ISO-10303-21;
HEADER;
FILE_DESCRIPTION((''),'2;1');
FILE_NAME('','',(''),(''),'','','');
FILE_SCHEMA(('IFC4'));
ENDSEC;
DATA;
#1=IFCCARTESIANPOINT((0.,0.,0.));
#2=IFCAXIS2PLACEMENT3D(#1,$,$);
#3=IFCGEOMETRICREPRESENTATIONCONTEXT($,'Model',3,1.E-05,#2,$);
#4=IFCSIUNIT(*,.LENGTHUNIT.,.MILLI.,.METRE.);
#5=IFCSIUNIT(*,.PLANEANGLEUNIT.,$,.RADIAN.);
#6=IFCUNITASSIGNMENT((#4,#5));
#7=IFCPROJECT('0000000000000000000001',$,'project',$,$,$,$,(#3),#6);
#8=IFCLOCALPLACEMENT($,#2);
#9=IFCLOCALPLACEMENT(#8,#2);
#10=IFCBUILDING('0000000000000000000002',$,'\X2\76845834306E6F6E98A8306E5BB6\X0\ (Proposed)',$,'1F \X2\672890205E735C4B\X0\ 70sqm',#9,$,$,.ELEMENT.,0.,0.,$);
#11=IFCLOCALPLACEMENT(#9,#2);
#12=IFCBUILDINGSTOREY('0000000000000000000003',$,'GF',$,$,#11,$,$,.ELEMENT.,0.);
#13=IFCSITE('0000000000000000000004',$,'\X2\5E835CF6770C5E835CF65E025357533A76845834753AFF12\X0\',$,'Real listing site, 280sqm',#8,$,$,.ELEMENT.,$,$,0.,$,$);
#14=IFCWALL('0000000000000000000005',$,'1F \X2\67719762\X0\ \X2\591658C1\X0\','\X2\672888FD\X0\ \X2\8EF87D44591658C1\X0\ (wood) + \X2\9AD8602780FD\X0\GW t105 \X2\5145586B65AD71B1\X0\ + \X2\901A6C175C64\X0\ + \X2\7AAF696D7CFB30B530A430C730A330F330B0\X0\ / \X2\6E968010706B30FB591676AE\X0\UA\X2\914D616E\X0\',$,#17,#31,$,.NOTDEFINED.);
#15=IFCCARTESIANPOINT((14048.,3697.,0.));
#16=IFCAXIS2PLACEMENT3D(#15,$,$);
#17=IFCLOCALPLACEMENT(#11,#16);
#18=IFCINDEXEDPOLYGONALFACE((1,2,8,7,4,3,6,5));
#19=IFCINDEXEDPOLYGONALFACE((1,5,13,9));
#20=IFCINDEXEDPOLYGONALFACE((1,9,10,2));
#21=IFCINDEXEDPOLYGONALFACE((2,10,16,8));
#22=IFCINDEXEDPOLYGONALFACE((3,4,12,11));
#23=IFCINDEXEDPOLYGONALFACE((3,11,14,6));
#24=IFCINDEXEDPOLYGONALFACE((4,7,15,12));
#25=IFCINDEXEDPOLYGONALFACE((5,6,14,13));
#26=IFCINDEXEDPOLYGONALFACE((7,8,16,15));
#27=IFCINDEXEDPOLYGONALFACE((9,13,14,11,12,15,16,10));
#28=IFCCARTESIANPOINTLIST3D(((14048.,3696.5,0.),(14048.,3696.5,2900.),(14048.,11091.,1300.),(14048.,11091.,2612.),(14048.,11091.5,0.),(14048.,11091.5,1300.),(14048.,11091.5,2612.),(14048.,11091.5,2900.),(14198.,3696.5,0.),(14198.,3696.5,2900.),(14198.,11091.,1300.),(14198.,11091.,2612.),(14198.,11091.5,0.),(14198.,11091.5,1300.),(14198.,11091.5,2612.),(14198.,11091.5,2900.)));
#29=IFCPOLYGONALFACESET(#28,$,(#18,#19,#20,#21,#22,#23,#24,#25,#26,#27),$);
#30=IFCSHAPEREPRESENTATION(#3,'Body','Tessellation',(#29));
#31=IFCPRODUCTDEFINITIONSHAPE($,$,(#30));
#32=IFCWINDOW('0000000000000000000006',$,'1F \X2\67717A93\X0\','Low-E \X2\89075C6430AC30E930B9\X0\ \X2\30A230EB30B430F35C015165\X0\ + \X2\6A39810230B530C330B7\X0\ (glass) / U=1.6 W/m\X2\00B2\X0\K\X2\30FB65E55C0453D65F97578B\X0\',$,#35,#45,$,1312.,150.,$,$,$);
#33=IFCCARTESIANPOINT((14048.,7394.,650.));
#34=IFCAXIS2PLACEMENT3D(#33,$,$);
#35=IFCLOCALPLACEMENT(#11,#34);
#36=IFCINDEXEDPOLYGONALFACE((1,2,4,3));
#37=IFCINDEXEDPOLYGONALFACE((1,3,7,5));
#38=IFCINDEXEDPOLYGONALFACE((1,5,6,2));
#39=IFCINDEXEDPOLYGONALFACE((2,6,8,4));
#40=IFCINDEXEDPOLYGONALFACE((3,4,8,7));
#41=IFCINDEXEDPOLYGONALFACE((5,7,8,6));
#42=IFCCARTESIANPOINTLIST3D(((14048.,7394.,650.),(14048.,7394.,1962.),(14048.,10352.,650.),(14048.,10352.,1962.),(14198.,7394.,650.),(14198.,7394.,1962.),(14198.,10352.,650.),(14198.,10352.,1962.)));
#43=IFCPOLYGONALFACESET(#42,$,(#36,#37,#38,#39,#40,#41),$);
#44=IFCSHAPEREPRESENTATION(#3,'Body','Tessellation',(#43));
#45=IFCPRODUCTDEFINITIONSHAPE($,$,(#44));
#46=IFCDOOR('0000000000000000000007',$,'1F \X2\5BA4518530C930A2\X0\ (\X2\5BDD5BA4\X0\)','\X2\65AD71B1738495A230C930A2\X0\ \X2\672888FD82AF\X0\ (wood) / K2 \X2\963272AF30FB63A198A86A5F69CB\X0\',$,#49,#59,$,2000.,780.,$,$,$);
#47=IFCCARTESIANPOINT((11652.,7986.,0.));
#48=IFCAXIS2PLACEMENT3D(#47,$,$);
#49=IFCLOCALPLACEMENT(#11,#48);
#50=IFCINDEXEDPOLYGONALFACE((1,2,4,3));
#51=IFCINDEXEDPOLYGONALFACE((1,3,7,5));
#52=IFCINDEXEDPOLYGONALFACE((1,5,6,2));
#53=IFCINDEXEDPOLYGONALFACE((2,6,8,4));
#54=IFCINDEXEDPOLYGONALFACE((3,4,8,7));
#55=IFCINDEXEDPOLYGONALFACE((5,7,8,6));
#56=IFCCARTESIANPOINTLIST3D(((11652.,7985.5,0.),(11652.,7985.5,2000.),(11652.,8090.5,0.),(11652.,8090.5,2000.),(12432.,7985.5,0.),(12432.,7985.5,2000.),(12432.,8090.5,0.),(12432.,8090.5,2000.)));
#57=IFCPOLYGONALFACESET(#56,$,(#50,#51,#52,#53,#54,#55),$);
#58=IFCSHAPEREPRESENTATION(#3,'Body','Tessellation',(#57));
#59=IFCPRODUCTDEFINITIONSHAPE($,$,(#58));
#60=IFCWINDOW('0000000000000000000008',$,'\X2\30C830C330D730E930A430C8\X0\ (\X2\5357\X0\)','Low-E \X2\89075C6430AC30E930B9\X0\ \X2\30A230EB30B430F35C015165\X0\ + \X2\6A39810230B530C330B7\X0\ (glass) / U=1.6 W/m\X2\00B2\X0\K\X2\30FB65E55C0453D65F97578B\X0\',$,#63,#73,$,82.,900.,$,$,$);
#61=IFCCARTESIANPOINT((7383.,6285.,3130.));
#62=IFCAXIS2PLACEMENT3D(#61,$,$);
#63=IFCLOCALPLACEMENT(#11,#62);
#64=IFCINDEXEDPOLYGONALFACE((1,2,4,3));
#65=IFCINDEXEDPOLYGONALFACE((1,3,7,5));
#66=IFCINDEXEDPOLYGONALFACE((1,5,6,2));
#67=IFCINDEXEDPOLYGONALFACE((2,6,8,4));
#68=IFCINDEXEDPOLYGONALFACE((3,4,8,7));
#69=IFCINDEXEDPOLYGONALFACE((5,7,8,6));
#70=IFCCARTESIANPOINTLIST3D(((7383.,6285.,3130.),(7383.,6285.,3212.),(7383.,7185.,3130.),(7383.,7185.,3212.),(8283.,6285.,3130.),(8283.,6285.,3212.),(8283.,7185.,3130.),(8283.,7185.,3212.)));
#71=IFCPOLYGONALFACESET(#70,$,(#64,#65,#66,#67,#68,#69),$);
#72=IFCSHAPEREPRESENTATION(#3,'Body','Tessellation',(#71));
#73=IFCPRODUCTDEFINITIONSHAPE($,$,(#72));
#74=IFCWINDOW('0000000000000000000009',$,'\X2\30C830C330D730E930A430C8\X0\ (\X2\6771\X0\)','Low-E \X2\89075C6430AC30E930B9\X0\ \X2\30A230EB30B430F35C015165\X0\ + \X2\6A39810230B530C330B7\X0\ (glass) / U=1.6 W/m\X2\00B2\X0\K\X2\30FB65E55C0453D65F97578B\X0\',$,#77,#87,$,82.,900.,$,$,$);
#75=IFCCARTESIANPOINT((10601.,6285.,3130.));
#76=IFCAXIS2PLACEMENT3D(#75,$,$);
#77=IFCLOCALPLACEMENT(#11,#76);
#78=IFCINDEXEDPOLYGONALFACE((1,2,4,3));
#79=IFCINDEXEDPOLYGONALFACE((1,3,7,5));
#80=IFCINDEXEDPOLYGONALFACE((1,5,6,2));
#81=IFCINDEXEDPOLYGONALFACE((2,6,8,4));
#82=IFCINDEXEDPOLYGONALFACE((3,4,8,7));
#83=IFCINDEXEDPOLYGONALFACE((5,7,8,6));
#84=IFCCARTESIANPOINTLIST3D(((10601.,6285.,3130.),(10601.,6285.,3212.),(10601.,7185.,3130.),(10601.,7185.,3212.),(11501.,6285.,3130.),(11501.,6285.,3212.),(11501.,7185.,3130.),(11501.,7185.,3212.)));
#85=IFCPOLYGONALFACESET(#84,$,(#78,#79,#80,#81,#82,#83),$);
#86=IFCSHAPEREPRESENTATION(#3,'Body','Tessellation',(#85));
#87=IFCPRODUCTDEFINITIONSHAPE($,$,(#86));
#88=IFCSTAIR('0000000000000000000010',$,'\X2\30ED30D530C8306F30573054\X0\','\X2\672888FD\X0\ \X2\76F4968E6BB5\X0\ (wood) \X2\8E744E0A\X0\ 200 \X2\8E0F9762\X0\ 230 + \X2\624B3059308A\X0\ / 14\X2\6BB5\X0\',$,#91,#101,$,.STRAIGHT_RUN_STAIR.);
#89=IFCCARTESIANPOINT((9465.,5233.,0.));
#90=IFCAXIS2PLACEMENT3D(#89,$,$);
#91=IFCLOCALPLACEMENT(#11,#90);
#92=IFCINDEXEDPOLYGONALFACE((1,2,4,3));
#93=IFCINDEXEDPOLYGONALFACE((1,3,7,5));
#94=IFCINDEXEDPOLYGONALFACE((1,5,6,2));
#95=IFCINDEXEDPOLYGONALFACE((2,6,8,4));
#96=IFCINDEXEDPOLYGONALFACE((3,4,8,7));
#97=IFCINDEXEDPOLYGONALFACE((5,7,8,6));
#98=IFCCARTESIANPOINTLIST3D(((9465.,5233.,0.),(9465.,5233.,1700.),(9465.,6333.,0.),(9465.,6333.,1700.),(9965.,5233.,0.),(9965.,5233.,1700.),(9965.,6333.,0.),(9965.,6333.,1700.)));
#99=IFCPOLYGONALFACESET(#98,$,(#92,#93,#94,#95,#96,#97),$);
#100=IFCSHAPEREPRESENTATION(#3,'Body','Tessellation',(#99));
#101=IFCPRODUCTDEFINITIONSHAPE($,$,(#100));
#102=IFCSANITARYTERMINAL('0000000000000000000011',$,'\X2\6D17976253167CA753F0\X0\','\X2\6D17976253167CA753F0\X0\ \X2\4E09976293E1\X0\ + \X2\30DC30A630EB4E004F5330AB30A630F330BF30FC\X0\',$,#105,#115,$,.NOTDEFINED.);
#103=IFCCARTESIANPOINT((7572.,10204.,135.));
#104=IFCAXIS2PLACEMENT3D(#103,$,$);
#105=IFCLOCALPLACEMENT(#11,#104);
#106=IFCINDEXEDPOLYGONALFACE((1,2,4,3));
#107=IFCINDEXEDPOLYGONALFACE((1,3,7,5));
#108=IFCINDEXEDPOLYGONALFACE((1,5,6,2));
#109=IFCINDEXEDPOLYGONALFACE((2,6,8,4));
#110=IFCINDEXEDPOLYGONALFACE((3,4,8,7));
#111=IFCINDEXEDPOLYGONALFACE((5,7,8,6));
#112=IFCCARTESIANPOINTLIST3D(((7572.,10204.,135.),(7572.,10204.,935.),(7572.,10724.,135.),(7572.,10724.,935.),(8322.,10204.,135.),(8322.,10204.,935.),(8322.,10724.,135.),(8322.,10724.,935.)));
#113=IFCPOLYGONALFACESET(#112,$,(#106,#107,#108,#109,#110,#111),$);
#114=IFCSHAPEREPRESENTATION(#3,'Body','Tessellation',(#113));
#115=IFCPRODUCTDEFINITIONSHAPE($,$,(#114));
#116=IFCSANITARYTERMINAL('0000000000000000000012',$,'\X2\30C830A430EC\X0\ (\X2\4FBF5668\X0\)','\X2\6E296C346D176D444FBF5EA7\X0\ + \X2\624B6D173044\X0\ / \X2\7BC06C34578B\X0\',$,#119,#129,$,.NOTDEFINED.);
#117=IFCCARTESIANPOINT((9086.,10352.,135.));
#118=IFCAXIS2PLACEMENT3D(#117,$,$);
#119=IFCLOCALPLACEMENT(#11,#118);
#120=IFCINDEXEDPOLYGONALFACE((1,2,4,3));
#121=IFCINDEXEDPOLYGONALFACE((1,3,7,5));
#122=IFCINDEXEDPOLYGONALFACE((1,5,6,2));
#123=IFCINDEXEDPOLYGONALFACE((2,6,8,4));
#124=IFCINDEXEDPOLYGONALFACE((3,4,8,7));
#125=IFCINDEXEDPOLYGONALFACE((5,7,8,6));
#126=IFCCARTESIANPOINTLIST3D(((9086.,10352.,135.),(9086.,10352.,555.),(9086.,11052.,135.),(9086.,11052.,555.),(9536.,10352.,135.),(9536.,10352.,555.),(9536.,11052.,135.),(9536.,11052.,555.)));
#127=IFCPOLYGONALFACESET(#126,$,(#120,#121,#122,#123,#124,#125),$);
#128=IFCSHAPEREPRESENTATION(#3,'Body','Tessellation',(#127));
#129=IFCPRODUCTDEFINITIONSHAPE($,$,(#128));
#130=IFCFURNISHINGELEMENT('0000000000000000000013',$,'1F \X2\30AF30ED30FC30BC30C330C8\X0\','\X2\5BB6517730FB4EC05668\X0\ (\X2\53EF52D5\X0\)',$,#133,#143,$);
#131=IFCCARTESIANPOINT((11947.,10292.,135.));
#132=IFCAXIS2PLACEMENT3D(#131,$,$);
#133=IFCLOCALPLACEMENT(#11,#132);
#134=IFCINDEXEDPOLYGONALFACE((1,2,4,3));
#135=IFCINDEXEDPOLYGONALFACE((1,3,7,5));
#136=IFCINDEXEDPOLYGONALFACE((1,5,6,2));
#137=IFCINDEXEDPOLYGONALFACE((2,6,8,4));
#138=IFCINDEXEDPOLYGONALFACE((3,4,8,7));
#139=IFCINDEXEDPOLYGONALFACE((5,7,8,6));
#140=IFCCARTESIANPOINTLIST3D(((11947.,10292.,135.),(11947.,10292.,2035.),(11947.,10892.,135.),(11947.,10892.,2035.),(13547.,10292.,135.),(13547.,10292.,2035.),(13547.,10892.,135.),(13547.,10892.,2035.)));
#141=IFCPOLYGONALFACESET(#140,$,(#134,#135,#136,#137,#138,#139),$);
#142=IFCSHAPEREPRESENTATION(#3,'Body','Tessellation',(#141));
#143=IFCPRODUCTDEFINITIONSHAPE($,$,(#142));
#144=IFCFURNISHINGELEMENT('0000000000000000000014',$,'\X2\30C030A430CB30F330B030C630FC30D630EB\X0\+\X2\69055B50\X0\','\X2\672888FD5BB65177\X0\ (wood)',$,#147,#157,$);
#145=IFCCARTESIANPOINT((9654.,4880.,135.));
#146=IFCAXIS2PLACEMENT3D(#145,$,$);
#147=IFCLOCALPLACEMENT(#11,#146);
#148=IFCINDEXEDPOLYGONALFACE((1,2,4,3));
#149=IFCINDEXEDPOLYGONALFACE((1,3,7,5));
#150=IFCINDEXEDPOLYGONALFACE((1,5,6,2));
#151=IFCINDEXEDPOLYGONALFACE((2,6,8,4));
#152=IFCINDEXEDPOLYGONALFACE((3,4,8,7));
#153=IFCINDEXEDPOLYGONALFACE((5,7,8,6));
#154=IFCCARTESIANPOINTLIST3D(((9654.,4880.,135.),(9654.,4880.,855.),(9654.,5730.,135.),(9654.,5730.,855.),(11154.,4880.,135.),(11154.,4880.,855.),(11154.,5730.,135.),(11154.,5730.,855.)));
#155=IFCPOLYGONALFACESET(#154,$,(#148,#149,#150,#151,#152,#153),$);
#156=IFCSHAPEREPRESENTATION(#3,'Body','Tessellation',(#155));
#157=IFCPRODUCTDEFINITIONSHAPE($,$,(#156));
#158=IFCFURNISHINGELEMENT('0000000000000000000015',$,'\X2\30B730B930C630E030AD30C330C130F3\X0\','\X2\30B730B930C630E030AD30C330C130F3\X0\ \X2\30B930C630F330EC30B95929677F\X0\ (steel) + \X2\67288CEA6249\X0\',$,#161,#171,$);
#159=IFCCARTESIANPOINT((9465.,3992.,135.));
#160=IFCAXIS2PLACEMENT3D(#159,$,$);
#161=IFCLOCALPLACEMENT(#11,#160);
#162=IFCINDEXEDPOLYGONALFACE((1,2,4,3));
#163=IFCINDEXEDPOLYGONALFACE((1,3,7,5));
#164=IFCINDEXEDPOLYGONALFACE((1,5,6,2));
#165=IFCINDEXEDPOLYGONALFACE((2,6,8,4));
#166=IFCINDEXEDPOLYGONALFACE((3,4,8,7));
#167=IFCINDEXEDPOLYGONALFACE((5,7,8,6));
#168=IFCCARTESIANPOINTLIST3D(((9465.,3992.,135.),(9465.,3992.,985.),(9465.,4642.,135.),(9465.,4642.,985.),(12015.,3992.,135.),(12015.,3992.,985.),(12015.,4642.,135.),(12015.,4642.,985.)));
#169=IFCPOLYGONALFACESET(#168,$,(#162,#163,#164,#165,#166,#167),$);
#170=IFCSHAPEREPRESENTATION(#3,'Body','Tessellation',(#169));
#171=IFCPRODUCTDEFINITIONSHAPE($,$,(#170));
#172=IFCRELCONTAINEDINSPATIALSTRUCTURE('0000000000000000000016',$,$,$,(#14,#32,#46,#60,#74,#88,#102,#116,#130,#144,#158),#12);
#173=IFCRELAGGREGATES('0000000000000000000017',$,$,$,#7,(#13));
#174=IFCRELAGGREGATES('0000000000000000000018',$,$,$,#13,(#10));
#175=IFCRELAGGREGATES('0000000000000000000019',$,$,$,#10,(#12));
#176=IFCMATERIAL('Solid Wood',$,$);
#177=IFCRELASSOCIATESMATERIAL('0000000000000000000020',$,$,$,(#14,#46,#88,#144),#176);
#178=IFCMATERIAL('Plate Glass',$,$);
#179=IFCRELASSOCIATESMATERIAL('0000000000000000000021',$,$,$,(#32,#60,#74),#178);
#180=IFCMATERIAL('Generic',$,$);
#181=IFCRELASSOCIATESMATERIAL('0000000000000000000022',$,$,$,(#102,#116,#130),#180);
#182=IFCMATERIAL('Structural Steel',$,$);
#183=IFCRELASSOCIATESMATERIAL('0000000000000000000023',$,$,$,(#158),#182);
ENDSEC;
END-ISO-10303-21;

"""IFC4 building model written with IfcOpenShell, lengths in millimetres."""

from ifc_helpers import new_model, si_unit, frame, frame_2d, origin, place, context, project, spatial, rectangle, extrude, material, element, fill, save


model = new_model("IFC4")

# Units and contexts
model_context = context("Model", 3, precision=1e-05, world=origin())
ifc_project = project(units=[si_unit("LENGTHUNIT", "METRE", prefix="MILLI"), si_unit("PLANEANGLEUNIT", "RADIAN")], contexts=[model_context])

# Site, building, storey
site_placement = place(None, origin())
site = spatial("IfcSite", under=ifc_project, at=site_placement, Name="広島県広島市南区的場町２", ObjectType="Real listing site, 280sqm", CompositionType="ELEMENT", RefElevation=0.0)
building_placement = place(site_placement, origin())
building = spatial("IfcBuilding", under=site, at=building_placement, Name="的場の潮風の家 (Proposed)", ObjectType="1F 木造平屋 70sqm", CompositionType="ELEMENT", ElevationOfRefHeight=0.0, ElevationOfTerrain=0.0)
storey_placement = place(building_placement, origin())
storey = spatial("IfcBuildingStorey", under=building, at=storey_placement, Name="GF", CompositionType="ELEMENT", Elevation=0.0)

# Wall, opening, window
ifc_material_1 = material(Name="Solid Wood")
wall_1_placement = place(storey_placement, frame((14048.0, 3697.0, 0.0)))
wall_1 = element("IfcWall", 1, at=wall_1_placement, inside=storey, material=ifc_material_1, Name="1F 東面 外壁", Description="木製 軸組外壁 (wood) + 高性能GW t105 充填断熱 + 通気層 + 窯業系サイディング / 準耐火・外皮UA配慮", PredefinedType="NOTDEFINED", context=model_context, shape_type="SweptSolid", body=[
    extrude(rectangle(XDim=150.0, YDim=7395.0, at=frame_2d((75.0, 3697.0))), frame((14048.0, 3697.0, 0.0)), (0.0, 0.0, 1.0), 2900.0),
])
opening_placement = place(storey_placement, frame((14048.0, 7394.0, 650.0)))
opening = element("IfcOpeningElement", 2, at=opening_placement, cuts=wall_1, PredefinedType="NOTDEFINED", context=model_context, shape_type="SweptSolid", body=[
    extrude(rectangle(XDim=150.0, YDim=2958.0, at=frame_2d((75.0, 1479.0))), frame((14048.0, 7394.0, 650.0)), (0.0, 0.0, 1.0), 1312.0),
])
ifc_material_2 = material(Name="Plate Glass")
window_1_placement = place(storey_placement, frame((14048.0, 7394.0, 650.0)))
window_1 = element("IfcWindow", 3, at=window_1_placement, inside=storey, material=ifc_material_2, Name="1F 東窓", Description="Low-E 複層ガラス アルゴン封入 + 樹脂サッシ (glass) / U=1.6 W/m²K・日射取得型", OverallHeight=1312.0, OverallWidth=150.0, context=model_context, shape_type="SweptSolid", body=[
    extrude(rectangle(XDim=150.0, YDim=2958.0, at=frame_2d((75.0, 1479.0))), frame((14048.0, 7394.0, 650.0)), (0.0, 0.0, 1.0), 1312.0),
])
fill(opening, window_1)

# Door
door_placement = place(storey_placement, frame((11652.0, 7986.0, 0.0)))
element("IfcDoor", 4, at=door_placement, inside=storey, material=ifc_material_1, Name="1F 室内ドア (寝室)", Description="断熱玄関ドア 木製芯 (wood) / K2 防犯・採風機構", OverallHeight=2000.0, OverallWidth=780.0, context=model_context, shape_type="SweptSolid", body=[
    extrude(rectangle(XDim=780.0, YDim=105.0, at=frame_2d((390.0, 52.0))), frame((11652.0, 7986.0, 0.0)), (0.0, 0.0, 1.0), 2000.0),
])

# Windows
window_2_placement = place(storey_placement, frame((7383.0, 6285.0, 3130.0)))
element("IfcWindow", 5, at=window_2_placement, inside=storey, material=ifc_material_2, Name="トップライト (南)", Description="Low-E 複層ガラス アルゴン封入 + 樹脂サッシ (glass) / U=1.6 W/m²K・日射取得型", OverallHeight=82.0, OverallWidth=900.0, context=model_context, shape_type="SweptSolid", body=[
    extrude(rectangle(XDim=900.0, YDim=900.0, at=frame_2d((450.0, 450.0))), frame((7383.0, 6285.0, 3130.0)), (0.0, 0.0, 1.0), 82.0),
])
window_3_placement = place(storey_placement, frame((10601.0, 6285.0, 3130.0)))
element("IfcWindow", 6, at=window_3_placement, inside=storey, material=ifc_material_2, Name="トップライト (東)", Description="Low-E 複層ガラス アルゴン封入 + 樹脂サッシ (glass) / U=1.6 W/m²K・日射取得型", OverallHeight=82.0, OverallWidth=900.0, context=model_context, shape_type="SweptSolid", body=[
    extrude(rectangle(XDim=900.0, YDim=900.0, at=frame_2d((450.0, 450.0))), frame((10601.0, 6285.0, 3130.0)), (0.0, 0.0, 1.0), 82.0),
])

# Stair
stair_placement = place(storey_placement, frame((9465.0, 5233.0, 0.0)))
element("IfcStair", 7, at=stair_placement, inside=storey, material=ifc_material_1, Name="ロフトはしご", Description="木製 直階段 (wood) 蹴上 200 踏面 230 + 手すり / 14段", PredefinedType="STRAIGHT_RUN_STAIR", context=model_context, shape_type="SweptSolid", body=[
    extrude(rectangle(XDim=500.0, YDim=1100.0, at=frame_2d((250.0, 550.0))), frame((9465.0, 5233.0, 0.0)), (0.0, 0.0, 1.0), 1700.0),
])

# Sanitary terminals
ifc_material_3 = material(Name="Generic")
sanitary_terminal_1_placement = place(storey_placement, frame((7572.0, 10204.0, 135.0)))
element("IfcSanitaryTerminal", 8, at=sanitary_terminal_1_placement, inside=storey, material=ifc_material_3, Name="洗面化粧台", Description="洗面化粧台 三面鏡 + ボウル一体カウンター", PredefinedType="NOTDEFINED", context=model_context, shape_type="SweptSolid", body=[
    extrude(rectangle(XDim=750.0, YDim=520.0, at=frame_2d((375.0, 260.0))), frame((7572.0, 10204.0, 135.0)), (0.0, 0.0, 1.0), 800.0),
])
sanitary_terminal_2_placement = place(storey_placement, frame((9086.0, 10352.0, 135.0)))
element("IfcSanitaryTerminal", 9, at=sanitary_terminal_2_placement, inside=storey, material=ifc_material_3, Name="トイレ (便器)", Description="温水洗浄便座 + 手洗い / 節水型", PredefinedType="NOTDEFINED", context=model_context, shape_type="SweptSolid", body=[
    extrude(rectangle(XDim=450.0, YDim=700.0, at=frame_2d((225.0, 350.0))), frame((9086.0, 10352.0, 135.0)), (0.0, 0.0, 1.0), 420.0),
])

# Furnishing elements
furnishing_1_placement = place(storey_placement, frame((11947.0, 10292.0, 135.0)))
element("IfcFurnishingElement", 10, at=furnishing_1_placement, inside=storey, material=ifc_material_3, Name="1F クローゼット", Description="家具・什器 (可動)", context=model_context, shape_type="SweptSolid", body=[
    extrude(rectangle(XDim=1600.0, YDim=600.0, at=frame_2d((800.0, 300.0))), frame((11947.0, 10292.0, 135.0)), (0.0, 0.0, 1.0), 1900.0),
])
furnishing_2_placement = place(storey_placement, frame((9654.0, 4880.0, 135.0)))
element("IfcFurnishingElement", 11, at=furnishing_2_placement, inside=storey, material=ifc_material_1, Name="ダイニングテーブル+椅子", Description="木製家具 (wood)", context=model_context, shape_type="SweptSolid", body=[
    extrude(rectangle(XDim=1500.0, YDim=850.0, at=frame_2d((750.0, 425.0))), frame((9654.0, 4880.0, 135.0)), (0.0, 0.0, 1.0), 720.0),
])
ifc_material_4 = material(Name="Structural Steel")
furnishing_3_placement = place(storey_placement, frame((9465.0, 3992.0, 135.0)))
element("IfcFurnishingElement", 12, at=furnishing_3_placement, inside=storey, material=ifc_material_4, Name="システムキッチン", Description="システムキッチン ステンレス天板 (steel) + 木質扉", context=model_context, shape_type="SweptSolid", body=[
    extrude(rectangle(XDim=2550.0, YDim=650.0, at=frame_2d((1275.0, 325.0))), frame((9465.0, 3992.0, 135.0)), (0.0, 0.0, 1.0), 850.0),
])

save(model, "model.ifc")
